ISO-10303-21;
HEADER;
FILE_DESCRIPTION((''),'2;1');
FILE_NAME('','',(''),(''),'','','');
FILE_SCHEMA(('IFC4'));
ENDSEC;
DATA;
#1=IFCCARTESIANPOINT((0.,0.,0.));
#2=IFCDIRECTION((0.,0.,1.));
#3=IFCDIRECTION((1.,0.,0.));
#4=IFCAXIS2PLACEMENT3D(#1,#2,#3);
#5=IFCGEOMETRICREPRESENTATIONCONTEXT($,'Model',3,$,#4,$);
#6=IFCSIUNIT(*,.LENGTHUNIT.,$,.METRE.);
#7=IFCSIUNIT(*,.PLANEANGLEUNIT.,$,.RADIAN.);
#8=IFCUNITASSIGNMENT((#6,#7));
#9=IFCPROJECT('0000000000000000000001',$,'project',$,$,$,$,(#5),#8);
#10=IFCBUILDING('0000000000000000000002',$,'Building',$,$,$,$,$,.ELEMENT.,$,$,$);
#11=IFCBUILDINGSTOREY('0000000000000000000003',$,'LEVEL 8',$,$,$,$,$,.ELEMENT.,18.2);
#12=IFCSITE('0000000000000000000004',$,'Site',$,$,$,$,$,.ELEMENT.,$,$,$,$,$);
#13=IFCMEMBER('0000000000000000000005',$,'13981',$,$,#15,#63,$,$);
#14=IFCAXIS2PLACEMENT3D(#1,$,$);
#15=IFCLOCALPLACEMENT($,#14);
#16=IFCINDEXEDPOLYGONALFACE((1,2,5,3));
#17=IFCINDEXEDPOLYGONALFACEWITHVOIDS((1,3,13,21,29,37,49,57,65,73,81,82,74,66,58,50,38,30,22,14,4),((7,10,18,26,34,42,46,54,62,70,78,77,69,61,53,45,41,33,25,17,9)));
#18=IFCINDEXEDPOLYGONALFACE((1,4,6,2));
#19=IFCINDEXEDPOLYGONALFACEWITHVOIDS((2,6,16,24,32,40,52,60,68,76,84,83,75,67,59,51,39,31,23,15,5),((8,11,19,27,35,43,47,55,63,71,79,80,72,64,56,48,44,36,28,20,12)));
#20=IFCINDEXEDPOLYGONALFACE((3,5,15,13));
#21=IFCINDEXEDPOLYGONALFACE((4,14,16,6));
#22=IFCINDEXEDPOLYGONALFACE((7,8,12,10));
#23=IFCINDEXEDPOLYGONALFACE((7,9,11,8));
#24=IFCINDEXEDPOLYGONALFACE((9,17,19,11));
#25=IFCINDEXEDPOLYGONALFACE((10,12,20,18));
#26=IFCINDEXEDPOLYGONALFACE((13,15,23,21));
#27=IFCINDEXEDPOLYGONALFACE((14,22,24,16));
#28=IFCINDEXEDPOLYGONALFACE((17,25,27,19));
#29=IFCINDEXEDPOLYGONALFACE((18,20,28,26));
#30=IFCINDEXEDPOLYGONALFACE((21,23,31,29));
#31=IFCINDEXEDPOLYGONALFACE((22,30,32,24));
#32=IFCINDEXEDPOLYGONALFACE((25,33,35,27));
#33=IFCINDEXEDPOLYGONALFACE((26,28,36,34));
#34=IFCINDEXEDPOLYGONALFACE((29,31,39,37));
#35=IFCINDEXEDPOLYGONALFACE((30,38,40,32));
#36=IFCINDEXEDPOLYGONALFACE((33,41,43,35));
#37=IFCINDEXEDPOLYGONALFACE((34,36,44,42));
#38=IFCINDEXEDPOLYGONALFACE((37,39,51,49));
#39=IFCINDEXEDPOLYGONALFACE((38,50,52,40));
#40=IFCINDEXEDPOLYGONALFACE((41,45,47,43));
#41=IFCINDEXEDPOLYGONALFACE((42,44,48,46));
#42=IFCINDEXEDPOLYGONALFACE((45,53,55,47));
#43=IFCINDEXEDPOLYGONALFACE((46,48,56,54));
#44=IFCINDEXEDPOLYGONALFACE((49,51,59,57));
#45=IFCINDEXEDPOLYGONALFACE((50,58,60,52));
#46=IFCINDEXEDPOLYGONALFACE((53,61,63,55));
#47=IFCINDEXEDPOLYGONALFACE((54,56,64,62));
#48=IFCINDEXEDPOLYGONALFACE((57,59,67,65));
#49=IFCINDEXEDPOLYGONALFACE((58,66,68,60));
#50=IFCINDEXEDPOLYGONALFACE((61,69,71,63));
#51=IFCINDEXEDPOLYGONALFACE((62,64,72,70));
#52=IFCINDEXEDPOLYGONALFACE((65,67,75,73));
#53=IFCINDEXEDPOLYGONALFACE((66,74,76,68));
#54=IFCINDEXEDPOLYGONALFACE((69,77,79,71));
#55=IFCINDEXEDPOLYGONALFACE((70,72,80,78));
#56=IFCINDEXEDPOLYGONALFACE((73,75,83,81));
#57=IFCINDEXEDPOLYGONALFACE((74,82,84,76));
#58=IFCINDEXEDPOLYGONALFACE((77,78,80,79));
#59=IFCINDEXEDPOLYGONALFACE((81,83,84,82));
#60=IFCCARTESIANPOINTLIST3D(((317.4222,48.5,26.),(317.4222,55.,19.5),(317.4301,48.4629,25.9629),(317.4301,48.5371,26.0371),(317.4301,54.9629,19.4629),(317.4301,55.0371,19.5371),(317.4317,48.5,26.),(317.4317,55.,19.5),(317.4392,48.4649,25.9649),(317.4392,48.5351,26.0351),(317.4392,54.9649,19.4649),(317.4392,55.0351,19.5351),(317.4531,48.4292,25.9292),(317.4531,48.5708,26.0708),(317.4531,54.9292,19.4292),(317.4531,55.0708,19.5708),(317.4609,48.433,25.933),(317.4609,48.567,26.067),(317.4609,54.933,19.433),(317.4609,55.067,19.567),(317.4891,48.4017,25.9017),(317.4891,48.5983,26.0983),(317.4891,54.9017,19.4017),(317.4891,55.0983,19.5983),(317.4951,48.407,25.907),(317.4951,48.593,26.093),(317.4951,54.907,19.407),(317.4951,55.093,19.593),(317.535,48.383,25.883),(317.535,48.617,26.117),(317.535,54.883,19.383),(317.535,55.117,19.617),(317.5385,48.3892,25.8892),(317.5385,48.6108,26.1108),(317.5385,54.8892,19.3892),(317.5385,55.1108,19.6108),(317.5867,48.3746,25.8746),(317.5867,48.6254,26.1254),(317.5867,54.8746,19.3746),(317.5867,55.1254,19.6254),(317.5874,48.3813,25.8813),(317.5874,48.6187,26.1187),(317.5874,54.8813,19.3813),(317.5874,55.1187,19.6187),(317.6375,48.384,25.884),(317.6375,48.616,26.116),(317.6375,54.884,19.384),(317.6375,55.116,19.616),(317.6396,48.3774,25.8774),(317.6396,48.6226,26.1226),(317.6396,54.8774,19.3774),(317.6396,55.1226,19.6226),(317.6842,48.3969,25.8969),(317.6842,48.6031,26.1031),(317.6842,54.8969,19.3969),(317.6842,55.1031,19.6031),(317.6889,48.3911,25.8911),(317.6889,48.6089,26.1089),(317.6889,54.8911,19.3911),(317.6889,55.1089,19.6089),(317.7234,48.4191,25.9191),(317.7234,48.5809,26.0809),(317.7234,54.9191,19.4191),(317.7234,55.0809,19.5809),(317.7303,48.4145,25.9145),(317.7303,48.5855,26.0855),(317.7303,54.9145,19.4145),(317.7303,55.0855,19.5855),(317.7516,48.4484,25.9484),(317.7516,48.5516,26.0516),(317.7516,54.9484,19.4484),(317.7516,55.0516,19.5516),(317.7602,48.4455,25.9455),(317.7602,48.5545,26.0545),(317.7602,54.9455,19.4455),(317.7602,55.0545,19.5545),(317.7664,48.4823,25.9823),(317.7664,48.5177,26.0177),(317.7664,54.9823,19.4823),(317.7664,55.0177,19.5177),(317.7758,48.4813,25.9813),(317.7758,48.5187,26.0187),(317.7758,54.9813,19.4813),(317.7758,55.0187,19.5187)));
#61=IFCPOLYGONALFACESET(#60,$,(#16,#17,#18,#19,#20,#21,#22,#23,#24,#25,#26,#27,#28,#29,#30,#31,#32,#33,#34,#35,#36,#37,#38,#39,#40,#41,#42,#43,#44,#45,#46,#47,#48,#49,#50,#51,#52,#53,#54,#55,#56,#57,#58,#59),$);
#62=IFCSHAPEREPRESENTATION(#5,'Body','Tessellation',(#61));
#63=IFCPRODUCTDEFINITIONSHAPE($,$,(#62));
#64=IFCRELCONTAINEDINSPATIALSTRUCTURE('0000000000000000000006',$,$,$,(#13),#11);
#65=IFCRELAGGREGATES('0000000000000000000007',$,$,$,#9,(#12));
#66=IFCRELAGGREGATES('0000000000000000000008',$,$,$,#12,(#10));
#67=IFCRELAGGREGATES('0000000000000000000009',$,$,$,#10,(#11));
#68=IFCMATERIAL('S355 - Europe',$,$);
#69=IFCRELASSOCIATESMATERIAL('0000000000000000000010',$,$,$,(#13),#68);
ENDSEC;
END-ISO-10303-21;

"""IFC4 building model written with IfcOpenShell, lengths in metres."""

from ifc_helpers import new_model, si_unit, frame, origin_with_axes, origin_2d_with_axis, place, context, project, spatial, hollow_circle, extrude, material, material_profile, profile_set, profile_usage, element, save


model = new_model("IFC4")

# Units and contexts
model_context = context("Model", 3, world=origin_with_axes())
ifc_project = project(units=[si_unit("LENGTHUNIT", "METRE"), si_unit("PLANEANGLEUNIT", "RADIAN")], contexts=[model_context])

# Site, building, storey
site = spatial("IfcSite", under=ifc_project, Name="Site", CompositionType="ELEMENT")
building = spatial("IfcBuilding", under=site, Name="Building", CompositionType="ELEMENT")
storey = spatial("IfcBuildingStorey", under=building, Name="LEVEL 8", CompositionType="ELEMENT", Elevation=18.2)

# Shared definitions
ifc_material = material(Name="S355 - Europe")

# Member
ifc_material_profile_1 = material_profile(ifc_material, hollow_circle(Radius=0.1778, WallThickness=0.0095, at=origin_2d_with_axis()))
ifc_profile_set_1 = profile_set([ifc_material_profile_1])
ifc_profile_usage_1 = profile_usage(ifc_profile_set_1, cardinal=10)
member_1_placement = place(None, frame((317.6, 48.5, 26.0), z_axis=(0.0, 0.707107, -0.707107), x_axis=(-1.0, 0.0, 0.0)))
element("IfcMember", 1, at=member_1_placement, inside=storey, material=ifc_profile_usage_1, Name="13981", context=model_context, shape_type="SweptSolid", body=[
    extrude(hollow_circle(Radius=0.1778, WallThickness=0.0095, at=origin_2d_with_axis()), origin_with_axes(), (0.0, 0.0, 1.0), 9.1924),
])

save(model, "model.ifc")
